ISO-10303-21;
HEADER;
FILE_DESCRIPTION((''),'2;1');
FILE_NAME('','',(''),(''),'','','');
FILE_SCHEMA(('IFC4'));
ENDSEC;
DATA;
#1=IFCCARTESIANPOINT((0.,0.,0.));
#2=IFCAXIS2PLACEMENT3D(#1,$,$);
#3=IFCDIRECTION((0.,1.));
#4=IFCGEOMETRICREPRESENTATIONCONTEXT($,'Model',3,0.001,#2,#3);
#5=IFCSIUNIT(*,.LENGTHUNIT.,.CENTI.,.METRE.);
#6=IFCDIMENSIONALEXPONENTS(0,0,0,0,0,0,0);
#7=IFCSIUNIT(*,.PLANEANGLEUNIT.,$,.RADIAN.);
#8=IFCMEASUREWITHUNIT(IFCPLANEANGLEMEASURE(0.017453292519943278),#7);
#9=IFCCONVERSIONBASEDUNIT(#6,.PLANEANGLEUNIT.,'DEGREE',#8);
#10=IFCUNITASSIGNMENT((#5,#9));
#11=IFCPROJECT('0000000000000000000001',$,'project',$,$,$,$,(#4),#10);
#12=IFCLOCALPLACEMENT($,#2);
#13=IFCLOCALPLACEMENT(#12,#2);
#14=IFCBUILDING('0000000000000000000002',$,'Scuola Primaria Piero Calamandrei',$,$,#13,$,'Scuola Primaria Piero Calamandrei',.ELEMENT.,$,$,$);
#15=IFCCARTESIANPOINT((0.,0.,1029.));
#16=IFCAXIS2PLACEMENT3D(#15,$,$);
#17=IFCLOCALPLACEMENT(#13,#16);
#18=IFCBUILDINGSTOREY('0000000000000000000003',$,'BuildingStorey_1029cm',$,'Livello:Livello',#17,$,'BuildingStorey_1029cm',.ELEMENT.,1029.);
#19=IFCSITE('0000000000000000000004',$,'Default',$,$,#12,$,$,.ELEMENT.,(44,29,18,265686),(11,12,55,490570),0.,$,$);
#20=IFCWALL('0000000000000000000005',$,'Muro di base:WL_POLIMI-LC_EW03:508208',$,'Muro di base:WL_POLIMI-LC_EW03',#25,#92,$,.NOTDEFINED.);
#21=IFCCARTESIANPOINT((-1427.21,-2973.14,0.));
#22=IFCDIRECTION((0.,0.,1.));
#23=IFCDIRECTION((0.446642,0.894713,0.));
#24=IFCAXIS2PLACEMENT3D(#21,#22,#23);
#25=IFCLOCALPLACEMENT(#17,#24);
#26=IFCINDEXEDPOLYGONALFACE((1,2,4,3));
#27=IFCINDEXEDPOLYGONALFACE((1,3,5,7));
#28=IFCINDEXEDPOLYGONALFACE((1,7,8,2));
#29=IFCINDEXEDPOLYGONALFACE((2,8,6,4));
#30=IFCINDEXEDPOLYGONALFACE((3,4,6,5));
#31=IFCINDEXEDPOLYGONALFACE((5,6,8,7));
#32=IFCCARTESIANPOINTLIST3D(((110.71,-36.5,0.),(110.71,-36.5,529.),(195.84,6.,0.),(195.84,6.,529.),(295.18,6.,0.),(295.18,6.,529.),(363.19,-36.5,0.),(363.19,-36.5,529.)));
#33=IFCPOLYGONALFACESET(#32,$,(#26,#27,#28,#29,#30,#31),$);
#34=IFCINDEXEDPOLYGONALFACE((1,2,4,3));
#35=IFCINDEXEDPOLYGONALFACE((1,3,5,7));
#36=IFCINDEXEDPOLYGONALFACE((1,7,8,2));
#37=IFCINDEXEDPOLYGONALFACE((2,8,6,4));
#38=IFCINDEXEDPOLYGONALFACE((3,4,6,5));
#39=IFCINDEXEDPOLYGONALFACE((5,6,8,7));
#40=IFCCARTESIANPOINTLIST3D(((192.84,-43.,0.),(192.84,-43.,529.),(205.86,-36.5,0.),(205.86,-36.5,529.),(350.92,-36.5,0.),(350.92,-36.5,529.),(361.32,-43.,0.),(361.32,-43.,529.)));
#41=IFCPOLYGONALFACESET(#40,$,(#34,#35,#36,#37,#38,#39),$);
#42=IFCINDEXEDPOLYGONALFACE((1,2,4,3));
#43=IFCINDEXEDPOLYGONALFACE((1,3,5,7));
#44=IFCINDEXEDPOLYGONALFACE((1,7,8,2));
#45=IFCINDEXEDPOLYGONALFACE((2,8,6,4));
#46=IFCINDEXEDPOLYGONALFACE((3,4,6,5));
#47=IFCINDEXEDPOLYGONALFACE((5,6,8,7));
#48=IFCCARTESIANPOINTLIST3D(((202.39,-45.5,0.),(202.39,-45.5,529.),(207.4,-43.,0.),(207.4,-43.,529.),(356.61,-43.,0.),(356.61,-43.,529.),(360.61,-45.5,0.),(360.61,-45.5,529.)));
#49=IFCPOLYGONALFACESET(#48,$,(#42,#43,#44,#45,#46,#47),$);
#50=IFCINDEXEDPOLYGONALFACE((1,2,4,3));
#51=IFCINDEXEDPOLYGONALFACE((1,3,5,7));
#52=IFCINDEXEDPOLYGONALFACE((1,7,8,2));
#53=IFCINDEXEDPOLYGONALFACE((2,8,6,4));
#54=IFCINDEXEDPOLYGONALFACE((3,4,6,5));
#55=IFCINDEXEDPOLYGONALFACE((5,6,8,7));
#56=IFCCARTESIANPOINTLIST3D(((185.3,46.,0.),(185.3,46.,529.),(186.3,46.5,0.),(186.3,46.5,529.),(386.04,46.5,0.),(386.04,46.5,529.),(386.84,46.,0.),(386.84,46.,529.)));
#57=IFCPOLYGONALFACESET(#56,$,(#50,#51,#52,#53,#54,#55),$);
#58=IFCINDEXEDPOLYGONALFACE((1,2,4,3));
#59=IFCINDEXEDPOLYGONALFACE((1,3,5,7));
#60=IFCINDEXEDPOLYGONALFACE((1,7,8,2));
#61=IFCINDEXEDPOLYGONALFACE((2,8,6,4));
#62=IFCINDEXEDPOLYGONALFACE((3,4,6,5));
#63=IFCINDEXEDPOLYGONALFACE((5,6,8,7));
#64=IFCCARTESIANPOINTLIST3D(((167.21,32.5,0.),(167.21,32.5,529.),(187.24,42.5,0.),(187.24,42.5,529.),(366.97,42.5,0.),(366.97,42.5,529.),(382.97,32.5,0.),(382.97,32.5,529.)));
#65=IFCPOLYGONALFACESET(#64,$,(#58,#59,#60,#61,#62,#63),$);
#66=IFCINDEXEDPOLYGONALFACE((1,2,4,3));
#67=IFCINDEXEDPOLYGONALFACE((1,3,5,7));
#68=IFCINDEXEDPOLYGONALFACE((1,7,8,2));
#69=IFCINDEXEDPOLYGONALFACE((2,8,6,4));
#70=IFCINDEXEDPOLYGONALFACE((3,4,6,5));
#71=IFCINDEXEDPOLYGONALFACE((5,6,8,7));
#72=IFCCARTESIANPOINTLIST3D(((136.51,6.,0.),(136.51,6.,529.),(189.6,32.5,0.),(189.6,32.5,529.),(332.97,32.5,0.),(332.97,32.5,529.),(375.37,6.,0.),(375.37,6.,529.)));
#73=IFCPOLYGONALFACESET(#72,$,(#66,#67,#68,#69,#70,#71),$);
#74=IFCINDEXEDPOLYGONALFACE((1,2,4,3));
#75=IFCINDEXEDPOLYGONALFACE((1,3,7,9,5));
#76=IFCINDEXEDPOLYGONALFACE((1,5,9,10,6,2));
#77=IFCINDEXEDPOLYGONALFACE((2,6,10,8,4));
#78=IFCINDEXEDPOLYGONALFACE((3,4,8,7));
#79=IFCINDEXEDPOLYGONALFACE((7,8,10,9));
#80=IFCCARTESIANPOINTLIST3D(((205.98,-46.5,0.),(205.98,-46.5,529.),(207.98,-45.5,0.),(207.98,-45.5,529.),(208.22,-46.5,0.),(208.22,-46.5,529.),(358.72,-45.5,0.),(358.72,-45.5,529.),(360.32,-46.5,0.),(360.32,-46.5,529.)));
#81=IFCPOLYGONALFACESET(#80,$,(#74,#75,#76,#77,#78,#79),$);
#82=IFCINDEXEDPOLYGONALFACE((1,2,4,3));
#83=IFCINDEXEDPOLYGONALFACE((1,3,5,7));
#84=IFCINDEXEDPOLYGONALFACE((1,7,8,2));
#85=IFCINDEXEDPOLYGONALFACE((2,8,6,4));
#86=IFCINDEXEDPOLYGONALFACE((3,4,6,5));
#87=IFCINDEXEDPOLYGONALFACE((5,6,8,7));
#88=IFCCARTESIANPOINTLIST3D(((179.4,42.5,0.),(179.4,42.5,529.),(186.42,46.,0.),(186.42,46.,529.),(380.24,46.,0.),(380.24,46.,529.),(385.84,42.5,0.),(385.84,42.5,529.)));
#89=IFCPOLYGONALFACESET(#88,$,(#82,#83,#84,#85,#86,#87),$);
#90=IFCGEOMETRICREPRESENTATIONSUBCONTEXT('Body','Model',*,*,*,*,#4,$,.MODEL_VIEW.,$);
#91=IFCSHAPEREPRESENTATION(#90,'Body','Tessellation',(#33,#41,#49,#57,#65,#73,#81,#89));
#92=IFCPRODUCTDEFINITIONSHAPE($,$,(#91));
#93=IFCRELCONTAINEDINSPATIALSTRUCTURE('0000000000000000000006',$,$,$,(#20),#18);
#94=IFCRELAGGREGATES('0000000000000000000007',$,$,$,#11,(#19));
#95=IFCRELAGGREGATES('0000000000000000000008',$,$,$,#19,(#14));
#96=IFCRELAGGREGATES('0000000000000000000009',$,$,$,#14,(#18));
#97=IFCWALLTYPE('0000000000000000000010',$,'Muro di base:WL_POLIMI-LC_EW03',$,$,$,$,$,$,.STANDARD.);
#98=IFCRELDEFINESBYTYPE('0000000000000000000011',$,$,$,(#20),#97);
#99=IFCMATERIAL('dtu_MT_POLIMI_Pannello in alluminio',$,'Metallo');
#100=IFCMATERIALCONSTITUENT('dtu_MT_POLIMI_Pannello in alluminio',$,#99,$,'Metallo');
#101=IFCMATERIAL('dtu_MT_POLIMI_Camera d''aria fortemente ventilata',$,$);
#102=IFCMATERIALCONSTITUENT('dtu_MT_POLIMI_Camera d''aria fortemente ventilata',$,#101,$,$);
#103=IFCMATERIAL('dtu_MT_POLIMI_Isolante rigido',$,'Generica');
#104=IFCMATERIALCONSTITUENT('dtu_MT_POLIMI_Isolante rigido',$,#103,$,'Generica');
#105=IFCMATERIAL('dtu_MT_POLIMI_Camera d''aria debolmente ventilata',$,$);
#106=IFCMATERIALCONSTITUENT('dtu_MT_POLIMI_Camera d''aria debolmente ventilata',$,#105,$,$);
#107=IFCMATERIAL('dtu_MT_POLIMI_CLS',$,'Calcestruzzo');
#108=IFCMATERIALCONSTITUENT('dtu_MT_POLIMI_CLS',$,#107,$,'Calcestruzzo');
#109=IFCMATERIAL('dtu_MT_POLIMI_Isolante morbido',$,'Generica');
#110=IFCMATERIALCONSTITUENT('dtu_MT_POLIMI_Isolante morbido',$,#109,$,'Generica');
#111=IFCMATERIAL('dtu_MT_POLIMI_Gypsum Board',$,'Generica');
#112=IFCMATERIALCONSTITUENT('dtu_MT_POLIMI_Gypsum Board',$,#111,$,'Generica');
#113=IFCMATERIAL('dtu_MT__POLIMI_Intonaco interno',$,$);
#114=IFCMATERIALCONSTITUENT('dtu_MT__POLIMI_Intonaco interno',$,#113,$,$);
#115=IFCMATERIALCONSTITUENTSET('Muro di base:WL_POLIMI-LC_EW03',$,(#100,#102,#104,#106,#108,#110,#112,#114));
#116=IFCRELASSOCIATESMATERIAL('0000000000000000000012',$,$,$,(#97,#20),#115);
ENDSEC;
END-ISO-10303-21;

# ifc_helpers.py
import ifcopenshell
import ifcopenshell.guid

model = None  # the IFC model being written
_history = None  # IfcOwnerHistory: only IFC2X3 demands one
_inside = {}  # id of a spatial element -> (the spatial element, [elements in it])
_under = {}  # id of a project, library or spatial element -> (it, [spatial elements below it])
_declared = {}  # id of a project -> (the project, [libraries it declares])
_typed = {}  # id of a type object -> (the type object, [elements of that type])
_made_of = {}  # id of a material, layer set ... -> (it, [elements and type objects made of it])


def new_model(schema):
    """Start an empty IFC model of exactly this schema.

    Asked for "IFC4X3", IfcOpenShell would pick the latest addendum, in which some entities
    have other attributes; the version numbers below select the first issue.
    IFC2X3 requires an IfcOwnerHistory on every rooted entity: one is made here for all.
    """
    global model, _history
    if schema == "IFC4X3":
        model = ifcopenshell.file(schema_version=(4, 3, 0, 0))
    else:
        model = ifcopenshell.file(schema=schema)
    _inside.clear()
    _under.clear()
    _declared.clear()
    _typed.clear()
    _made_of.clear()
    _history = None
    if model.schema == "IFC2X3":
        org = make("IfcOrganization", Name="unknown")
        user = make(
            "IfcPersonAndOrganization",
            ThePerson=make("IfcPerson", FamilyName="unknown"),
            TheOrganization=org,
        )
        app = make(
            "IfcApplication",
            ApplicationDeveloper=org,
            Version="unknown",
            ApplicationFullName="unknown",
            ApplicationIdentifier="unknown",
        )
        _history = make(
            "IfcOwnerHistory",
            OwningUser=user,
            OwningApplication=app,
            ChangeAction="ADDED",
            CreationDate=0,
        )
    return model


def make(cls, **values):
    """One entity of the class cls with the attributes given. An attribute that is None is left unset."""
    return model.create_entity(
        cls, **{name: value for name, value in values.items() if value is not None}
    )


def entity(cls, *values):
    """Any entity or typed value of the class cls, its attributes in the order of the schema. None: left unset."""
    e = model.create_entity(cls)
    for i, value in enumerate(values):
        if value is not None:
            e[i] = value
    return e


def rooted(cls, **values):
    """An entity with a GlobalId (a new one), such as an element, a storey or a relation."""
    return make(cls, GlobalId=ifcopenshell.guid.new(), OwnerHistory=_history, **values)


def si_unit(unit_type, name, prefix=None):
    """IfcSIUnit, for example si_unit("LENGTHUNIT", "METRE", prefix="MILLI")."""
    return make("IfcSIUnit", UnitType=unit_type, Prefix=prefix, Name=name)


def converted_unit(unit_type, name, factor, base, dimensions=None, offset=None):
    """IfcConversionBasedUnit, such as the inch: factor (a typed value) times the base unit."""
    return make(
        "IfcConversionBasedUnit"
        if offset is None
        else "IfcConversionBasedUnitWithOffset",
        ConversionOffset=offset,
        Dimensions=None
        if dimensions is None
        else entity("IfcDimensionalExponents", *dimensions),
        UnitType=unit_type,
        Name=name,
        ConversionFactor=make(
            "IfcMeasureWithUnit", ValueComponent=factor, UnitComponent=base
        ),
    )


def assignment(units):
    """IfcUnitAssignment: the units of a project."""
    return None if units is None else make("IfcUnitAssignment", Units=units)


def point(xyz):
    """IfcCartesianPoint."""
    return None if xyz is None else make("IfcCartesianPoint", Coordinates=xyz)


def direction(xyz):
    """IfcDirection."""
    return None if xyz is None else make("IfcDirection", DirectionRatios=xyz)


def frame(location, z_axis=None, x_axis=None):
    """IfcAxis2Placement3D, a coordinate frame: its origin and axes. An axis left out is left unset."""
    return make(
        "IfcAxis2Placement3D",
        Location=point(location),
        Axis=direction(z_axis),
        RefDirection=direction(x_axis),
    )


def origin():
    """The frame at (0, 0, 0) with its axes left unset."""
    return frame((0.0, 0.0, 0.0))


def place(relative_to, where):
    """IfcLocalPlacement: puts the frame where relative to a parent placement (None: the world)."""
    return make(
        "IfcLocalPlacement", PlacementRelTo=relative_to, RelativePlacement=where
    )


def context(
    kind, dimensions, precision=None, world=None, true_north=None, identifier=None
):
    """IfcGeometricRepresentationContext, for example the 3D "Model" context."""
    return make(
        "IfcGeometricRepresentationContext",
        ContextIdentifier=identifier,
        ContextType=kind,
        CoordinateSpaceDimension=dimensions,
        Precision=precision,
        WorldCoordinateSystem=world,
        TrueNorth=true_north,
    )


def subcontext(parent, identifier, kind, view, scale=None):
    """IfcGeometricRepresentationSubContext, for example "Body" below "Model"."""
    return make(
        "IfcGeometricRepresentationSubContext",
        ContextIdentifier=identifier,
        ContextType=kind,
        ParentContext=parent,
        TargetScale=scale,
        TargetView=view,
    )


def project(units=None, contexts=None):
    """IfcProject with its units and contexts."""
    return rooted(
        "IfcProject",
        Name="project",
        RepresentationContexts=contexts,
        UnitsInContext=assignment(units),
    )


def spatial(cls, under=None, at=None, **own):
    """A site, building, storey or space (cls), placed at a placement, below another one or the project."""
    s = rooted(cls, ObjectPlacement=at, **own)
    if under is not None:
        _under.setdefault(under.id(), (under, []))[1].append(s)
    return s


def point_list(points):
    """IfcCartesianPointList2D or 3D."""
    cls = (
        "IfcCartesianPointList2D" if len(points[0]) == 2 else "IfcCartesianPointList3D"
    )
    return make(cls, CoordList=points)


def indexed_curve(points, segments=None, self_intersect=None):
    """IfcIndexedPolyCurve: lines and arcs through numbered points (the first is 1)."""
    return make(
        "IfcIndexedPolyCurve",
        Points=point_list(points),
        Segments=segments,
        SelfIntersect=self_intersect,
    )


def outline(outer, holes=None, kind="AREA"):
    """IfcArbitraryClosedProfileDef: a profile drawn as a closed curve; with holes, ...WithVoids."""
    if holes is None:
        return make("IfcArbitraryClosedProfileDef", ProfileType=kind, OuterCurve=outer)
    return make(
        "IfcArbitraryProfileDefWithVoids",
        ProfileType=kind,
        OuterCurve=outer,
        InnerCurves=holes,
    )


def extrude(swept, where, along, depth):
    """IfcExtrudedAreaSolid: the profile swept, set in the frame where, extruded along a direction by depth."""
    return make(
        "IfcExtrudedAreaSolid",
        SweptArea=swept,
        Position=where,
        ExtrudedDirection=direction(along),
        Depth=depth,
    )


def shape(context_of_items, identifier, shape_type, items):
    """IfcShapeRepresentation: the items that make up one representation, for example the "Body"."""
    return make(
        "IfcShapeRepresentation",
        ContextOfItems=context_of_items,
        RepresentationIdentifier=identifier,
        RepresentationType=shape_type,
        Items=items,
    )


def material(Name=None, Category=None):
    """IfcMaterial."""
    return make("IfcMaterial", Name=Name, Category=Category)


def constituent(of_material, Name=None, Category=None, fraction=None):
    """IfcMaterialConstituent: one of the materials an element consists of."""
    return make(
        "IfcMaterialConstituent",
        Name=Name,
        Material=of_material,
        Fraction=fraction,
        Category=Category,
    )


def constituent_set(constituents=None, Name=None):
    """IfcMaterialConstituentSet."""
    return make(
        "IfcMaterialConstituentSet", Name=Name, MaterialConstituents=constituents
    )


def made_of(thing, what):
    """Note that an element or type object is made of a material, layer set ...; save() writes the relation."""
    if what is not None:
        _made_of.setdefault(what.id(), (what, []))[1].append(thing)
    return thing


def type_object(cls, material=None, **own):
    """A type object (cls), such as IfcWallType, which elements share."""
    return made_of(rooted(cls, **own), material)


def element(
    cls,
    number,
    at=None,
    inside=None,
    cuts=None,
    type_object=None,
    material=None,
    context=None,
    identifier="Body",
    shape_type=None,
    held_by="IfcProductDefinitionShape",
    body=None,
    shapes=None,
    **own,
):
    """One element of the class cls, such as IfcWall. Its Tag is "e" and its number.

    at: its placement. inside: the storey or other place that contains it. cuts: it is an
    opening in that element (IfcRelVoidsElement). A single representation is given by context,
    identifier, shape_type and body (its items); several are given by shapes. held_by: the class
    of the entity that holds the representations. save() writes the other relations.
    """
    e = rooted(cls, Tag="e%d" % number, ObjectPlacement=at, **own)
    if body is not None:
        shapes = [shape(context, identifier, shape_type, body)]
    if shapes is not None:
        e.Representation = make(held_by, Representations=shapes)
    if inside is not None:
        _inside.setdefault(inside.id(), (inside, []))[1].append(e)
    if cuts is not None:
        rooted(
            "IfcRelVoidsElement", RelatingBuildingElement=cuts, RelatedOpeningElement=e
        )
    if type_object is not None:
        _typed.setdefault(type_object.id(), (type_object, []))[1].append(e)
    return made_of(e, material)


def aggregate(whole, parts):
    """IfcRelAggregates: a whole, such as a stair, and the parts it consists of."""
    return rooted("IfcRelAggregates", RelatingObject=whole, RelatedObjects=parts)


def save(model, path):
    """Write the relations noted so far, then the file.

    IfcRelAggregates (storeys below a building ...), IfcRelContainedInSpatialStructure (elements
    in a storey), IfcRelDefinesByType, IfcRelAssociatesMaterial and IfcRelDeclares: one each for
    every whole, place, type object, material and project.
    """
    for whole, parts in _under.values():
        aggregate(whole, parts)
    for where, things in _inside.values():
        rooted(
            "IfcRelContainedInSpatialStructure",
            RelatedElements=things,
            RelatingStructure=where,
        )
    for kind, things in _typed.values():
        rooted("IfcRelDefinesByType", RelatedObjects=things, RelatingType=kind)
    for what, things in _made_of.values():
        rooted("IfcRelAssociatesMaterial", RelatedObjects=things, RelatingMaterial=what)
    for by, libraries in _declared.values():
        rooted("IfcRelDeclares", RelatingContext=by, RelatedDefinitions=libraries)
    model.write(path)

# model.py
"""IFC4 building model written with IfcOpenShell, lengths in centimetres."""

from ifc_helpers import new_model, entity, si_unit, converted_unit, direction, frame, origin, place, context, subcontext, project, spatial, indexed_curve, outline, extrude, material, constituent, constituent_set, type_object, element, save


model = new_model("IFC4")

# Units and contexts
model_context = context("Model", 3, precision=0.001, world=origin(), true_north=direction((0.0, 1.0)))
body_context = subcontext(model_context, "Body", "Model", "MODEL_VIEW")
ifc_project = project(units=[si_unit("LENGTHUNIT", "METRE", prefix="CENTI"), converted_unit("PLANEANGLEUNIT", "DEGREE", entity("IfcPlaneAngleMeasure", 0.017453292519943278), si_unit("PLANEANGLEUNIT", "RADIAN"), dimensions=[0, 0, 0, 0, 0, 0, 0])], contexts=[model_context])

# Site, building, storey
site_placement = place(None, origin())
site = spatial("IfcSite", under=ifc_project, at=site_placement, Name="Default", CompositionType="ELEMENT", RefLatitude=(44, 29, 18, 265686), RefLongitude=(11, 12, 55, 490570), RefElevation=0.0)
building_placement = place(site_placement, origin())
building = spatial("IfcBuilding", under=site, at=building_placement, Name="Scuola Primaria Piero Calamandrei", LongName="Scuola Primaria Piero Calamandrei", CompositionType="ELEMENT")
storey_placement = place(building_placement, frame((0.0, 0.0, 1029.0)))
storey = spatial("IfcBuildingStorey", under=building, at=storey_placement, Name="BuildingStorey_1029cm", ObjectType="Livello:Livello", LongName="BuildingStorey_1029cm", CompositionType="ELEMENT", Elevation=1029.0)

# Shared definitions
ifc_material_1 = material(Name="dtu_MT_POLIMI_Isolante rigido", Category="Generica")
ifc_material_2 = material(Name="dtu_MT__POLIMI_Intonaco interno")

# Wall
ifc_material_3 = material(Name="dtu_MT_POLIMI_Pannello in alluminio", Category="Metallo")
ifc_constituent_1 = constituent(ifc_material_3, Name="dtu_MT_POLIMI_Pannello in alluminio", Category="Metallo")
ifc_material_4 = material(Name="dtu_MT_POLIMI_Camera d'aria fortemente ventilata")
ifc_constituent_2 = constituent(ifc_material_4, Name="dtu_MT_POLIMI_Camera d'aria fortemente ventilata")
ifc_constituent_3 = constituent(ifc_material_1, Name="dtu_MT_POLIMI_Isolante rigido", Category="Generica")
ifc_material_5 = material(Name="dtu_MT_POLIMI_Camera d'aria debolmente ventilata")
ifc_constituent_4 = constituent(ifc_material_5, Name="dtu_MT_POLIMI_Camera d'aria debolmente ventilata")
ifc_material_6 = material(Name="dtu_MT_POLIMI_CLS", Category="Calcestruzzo")
ifc_constituent_5 = constituent(ifc_material_6, Name="dtu_MT_POLIMI_CLS", Category="Calcestruzzo")
ifc_material_7 = material(Name="dtu_MT_POLIMI_Isolante morbido", Category="Generica")
ifc_constituent_6 = constituent(ifc_material_7, Name="dtu_MT_POLIMI_Isolante morbido", Category="Generica")
ifc_material_8 = material(Name="dtu_MT_POLIMI_Gypsum Board", Category="Generica")
ifc_constituent_7 = constituent(ifc_material_8, Name="dtu_MT_POLIMI_Gypsum Board", Category="Generica")
ifc_constituent_8 = constituent(ifc_material_2, Name="dtu_MT__POLIMI_Intonaco interno")
ifc_constituent_set_1 = constituent_set(constituents=[ifc_constituent_1, ifc_constituent_2, ifc_constituent_3, ifc_constituent_4, ifc_constituent_5, ifc_constituent_6, ifc_constituent_7, ifc_constituent_8], Name="Muro di base:WL_POLIMI-LC_EW03")
wall_type_1 = type_object("IfcWallType", Name="Muro di base:WL_POLIMI-LC_EW03", PredefinedType="STANDARD", material=ifc_constituent_set_1)
wall_1_placement = place(storey_placement, frame((-1427.21, -2973.14, 0.0), z_axis=(0.0, 0.0, 1.0), x_axis=(0.446642, 0.894713, 0.0)))
element("IfcWall", 1, at=wall_1_placement, inside=storey, type_object=wall_type_1, material=ifc_constituent_set_1, Name="Muro di base:WL_POLIMI-LC_EW03:508208", ObjectType="Muro di base:WL_POLIMI-LC_EW03", PredefinedType="NOTDEFINED", context=body_context, shape_type="SweptSolid", body=[
    extrude(outline(indexed_curve([(-130.52, -21.25), (121.96, -21.25), (53.95, 21.25), (-45.38, 21.25), (-130.52, -21.25)], self_intersect=False)), frame((241.23, -15.25, 0.0)), (0.0, 0.0, 1.0), 529.0),
    extrude(outline(indexed_curve([(-84.89, -3.25), (83.59, -3.25), (73.18, 3.25), (-71.87, 3.25), (-84.89, -3.25)], self_intersect=False)), frame((277.74, -39.75, 0.0)), (0.0, 0.0, 1.0), 529.0),
    extrude(outline(indexed_curve([(-79.36, -1.25), (78.86, -1.25), (74.86, 1.25), (-74.35, 1.25), (-79.36, -1.25)], self_intersect=False)), frame((281.75, -44.25, 0.0)), (0.0, 0.0, 1.0), 529.0),
    extrude(outline(indexed_curve([(89.2, -44.81), (90.32, -44.81), (-90.01, 45.21), (-89.51, 44.41), (89.2, -44.81)], self_intersect=False)), frame((286.12, 46.25, 0.0), z_axis=(0.0, 0.0, 1.0), x_axis=(-0.894713, -0.446642, 0.0)), (0.0, 0.0, 1.0), 529.0),
    extrude(outline(indexed_curve([(-108.89, -5.0), (106.87, -5.0), (90.87, 5.0), (-88.86, 5.0), (-108.89, -5.0)], self_intersect=False)), frame((276.1, 37.5, 0.0)), (0.0, 0.0, 1.0), 529.0),
    extrude(outline(indexed_curve([(-122.1, -13.25), (116.76, -13.25), (74.35, 13.25), (-69.02, 13.25), (-122.1, -13.25)], self_intersect=False)), frame((258.61, 19.25, 0.0)), (0.0, 0.0, 1.0), 529.0),
    extrude(outline(indexed_curve([(-60.02, -0.4), (92.07, -0.4), (90.47, 0.6), (-60.26, 0.6), (-62.26, -0.4), (-60.02, -0.4)], self_intersect=False)), frame((268.24, -46.1, 0.0)), (0.0, 0.0, 1.0), 529.0),
    extrude(outline(indexed_curve([(-103.57, -1.75), (102.87, -1.75), (97.26, 1.75), (-96.56, 1.75), (-103.57, -1.75)], self_intersect=False)), frame((282.97, 44.25, 0.0)), (0.0, 0.0, 1.0), 529.0),
])

save(model, "model.ifc")
